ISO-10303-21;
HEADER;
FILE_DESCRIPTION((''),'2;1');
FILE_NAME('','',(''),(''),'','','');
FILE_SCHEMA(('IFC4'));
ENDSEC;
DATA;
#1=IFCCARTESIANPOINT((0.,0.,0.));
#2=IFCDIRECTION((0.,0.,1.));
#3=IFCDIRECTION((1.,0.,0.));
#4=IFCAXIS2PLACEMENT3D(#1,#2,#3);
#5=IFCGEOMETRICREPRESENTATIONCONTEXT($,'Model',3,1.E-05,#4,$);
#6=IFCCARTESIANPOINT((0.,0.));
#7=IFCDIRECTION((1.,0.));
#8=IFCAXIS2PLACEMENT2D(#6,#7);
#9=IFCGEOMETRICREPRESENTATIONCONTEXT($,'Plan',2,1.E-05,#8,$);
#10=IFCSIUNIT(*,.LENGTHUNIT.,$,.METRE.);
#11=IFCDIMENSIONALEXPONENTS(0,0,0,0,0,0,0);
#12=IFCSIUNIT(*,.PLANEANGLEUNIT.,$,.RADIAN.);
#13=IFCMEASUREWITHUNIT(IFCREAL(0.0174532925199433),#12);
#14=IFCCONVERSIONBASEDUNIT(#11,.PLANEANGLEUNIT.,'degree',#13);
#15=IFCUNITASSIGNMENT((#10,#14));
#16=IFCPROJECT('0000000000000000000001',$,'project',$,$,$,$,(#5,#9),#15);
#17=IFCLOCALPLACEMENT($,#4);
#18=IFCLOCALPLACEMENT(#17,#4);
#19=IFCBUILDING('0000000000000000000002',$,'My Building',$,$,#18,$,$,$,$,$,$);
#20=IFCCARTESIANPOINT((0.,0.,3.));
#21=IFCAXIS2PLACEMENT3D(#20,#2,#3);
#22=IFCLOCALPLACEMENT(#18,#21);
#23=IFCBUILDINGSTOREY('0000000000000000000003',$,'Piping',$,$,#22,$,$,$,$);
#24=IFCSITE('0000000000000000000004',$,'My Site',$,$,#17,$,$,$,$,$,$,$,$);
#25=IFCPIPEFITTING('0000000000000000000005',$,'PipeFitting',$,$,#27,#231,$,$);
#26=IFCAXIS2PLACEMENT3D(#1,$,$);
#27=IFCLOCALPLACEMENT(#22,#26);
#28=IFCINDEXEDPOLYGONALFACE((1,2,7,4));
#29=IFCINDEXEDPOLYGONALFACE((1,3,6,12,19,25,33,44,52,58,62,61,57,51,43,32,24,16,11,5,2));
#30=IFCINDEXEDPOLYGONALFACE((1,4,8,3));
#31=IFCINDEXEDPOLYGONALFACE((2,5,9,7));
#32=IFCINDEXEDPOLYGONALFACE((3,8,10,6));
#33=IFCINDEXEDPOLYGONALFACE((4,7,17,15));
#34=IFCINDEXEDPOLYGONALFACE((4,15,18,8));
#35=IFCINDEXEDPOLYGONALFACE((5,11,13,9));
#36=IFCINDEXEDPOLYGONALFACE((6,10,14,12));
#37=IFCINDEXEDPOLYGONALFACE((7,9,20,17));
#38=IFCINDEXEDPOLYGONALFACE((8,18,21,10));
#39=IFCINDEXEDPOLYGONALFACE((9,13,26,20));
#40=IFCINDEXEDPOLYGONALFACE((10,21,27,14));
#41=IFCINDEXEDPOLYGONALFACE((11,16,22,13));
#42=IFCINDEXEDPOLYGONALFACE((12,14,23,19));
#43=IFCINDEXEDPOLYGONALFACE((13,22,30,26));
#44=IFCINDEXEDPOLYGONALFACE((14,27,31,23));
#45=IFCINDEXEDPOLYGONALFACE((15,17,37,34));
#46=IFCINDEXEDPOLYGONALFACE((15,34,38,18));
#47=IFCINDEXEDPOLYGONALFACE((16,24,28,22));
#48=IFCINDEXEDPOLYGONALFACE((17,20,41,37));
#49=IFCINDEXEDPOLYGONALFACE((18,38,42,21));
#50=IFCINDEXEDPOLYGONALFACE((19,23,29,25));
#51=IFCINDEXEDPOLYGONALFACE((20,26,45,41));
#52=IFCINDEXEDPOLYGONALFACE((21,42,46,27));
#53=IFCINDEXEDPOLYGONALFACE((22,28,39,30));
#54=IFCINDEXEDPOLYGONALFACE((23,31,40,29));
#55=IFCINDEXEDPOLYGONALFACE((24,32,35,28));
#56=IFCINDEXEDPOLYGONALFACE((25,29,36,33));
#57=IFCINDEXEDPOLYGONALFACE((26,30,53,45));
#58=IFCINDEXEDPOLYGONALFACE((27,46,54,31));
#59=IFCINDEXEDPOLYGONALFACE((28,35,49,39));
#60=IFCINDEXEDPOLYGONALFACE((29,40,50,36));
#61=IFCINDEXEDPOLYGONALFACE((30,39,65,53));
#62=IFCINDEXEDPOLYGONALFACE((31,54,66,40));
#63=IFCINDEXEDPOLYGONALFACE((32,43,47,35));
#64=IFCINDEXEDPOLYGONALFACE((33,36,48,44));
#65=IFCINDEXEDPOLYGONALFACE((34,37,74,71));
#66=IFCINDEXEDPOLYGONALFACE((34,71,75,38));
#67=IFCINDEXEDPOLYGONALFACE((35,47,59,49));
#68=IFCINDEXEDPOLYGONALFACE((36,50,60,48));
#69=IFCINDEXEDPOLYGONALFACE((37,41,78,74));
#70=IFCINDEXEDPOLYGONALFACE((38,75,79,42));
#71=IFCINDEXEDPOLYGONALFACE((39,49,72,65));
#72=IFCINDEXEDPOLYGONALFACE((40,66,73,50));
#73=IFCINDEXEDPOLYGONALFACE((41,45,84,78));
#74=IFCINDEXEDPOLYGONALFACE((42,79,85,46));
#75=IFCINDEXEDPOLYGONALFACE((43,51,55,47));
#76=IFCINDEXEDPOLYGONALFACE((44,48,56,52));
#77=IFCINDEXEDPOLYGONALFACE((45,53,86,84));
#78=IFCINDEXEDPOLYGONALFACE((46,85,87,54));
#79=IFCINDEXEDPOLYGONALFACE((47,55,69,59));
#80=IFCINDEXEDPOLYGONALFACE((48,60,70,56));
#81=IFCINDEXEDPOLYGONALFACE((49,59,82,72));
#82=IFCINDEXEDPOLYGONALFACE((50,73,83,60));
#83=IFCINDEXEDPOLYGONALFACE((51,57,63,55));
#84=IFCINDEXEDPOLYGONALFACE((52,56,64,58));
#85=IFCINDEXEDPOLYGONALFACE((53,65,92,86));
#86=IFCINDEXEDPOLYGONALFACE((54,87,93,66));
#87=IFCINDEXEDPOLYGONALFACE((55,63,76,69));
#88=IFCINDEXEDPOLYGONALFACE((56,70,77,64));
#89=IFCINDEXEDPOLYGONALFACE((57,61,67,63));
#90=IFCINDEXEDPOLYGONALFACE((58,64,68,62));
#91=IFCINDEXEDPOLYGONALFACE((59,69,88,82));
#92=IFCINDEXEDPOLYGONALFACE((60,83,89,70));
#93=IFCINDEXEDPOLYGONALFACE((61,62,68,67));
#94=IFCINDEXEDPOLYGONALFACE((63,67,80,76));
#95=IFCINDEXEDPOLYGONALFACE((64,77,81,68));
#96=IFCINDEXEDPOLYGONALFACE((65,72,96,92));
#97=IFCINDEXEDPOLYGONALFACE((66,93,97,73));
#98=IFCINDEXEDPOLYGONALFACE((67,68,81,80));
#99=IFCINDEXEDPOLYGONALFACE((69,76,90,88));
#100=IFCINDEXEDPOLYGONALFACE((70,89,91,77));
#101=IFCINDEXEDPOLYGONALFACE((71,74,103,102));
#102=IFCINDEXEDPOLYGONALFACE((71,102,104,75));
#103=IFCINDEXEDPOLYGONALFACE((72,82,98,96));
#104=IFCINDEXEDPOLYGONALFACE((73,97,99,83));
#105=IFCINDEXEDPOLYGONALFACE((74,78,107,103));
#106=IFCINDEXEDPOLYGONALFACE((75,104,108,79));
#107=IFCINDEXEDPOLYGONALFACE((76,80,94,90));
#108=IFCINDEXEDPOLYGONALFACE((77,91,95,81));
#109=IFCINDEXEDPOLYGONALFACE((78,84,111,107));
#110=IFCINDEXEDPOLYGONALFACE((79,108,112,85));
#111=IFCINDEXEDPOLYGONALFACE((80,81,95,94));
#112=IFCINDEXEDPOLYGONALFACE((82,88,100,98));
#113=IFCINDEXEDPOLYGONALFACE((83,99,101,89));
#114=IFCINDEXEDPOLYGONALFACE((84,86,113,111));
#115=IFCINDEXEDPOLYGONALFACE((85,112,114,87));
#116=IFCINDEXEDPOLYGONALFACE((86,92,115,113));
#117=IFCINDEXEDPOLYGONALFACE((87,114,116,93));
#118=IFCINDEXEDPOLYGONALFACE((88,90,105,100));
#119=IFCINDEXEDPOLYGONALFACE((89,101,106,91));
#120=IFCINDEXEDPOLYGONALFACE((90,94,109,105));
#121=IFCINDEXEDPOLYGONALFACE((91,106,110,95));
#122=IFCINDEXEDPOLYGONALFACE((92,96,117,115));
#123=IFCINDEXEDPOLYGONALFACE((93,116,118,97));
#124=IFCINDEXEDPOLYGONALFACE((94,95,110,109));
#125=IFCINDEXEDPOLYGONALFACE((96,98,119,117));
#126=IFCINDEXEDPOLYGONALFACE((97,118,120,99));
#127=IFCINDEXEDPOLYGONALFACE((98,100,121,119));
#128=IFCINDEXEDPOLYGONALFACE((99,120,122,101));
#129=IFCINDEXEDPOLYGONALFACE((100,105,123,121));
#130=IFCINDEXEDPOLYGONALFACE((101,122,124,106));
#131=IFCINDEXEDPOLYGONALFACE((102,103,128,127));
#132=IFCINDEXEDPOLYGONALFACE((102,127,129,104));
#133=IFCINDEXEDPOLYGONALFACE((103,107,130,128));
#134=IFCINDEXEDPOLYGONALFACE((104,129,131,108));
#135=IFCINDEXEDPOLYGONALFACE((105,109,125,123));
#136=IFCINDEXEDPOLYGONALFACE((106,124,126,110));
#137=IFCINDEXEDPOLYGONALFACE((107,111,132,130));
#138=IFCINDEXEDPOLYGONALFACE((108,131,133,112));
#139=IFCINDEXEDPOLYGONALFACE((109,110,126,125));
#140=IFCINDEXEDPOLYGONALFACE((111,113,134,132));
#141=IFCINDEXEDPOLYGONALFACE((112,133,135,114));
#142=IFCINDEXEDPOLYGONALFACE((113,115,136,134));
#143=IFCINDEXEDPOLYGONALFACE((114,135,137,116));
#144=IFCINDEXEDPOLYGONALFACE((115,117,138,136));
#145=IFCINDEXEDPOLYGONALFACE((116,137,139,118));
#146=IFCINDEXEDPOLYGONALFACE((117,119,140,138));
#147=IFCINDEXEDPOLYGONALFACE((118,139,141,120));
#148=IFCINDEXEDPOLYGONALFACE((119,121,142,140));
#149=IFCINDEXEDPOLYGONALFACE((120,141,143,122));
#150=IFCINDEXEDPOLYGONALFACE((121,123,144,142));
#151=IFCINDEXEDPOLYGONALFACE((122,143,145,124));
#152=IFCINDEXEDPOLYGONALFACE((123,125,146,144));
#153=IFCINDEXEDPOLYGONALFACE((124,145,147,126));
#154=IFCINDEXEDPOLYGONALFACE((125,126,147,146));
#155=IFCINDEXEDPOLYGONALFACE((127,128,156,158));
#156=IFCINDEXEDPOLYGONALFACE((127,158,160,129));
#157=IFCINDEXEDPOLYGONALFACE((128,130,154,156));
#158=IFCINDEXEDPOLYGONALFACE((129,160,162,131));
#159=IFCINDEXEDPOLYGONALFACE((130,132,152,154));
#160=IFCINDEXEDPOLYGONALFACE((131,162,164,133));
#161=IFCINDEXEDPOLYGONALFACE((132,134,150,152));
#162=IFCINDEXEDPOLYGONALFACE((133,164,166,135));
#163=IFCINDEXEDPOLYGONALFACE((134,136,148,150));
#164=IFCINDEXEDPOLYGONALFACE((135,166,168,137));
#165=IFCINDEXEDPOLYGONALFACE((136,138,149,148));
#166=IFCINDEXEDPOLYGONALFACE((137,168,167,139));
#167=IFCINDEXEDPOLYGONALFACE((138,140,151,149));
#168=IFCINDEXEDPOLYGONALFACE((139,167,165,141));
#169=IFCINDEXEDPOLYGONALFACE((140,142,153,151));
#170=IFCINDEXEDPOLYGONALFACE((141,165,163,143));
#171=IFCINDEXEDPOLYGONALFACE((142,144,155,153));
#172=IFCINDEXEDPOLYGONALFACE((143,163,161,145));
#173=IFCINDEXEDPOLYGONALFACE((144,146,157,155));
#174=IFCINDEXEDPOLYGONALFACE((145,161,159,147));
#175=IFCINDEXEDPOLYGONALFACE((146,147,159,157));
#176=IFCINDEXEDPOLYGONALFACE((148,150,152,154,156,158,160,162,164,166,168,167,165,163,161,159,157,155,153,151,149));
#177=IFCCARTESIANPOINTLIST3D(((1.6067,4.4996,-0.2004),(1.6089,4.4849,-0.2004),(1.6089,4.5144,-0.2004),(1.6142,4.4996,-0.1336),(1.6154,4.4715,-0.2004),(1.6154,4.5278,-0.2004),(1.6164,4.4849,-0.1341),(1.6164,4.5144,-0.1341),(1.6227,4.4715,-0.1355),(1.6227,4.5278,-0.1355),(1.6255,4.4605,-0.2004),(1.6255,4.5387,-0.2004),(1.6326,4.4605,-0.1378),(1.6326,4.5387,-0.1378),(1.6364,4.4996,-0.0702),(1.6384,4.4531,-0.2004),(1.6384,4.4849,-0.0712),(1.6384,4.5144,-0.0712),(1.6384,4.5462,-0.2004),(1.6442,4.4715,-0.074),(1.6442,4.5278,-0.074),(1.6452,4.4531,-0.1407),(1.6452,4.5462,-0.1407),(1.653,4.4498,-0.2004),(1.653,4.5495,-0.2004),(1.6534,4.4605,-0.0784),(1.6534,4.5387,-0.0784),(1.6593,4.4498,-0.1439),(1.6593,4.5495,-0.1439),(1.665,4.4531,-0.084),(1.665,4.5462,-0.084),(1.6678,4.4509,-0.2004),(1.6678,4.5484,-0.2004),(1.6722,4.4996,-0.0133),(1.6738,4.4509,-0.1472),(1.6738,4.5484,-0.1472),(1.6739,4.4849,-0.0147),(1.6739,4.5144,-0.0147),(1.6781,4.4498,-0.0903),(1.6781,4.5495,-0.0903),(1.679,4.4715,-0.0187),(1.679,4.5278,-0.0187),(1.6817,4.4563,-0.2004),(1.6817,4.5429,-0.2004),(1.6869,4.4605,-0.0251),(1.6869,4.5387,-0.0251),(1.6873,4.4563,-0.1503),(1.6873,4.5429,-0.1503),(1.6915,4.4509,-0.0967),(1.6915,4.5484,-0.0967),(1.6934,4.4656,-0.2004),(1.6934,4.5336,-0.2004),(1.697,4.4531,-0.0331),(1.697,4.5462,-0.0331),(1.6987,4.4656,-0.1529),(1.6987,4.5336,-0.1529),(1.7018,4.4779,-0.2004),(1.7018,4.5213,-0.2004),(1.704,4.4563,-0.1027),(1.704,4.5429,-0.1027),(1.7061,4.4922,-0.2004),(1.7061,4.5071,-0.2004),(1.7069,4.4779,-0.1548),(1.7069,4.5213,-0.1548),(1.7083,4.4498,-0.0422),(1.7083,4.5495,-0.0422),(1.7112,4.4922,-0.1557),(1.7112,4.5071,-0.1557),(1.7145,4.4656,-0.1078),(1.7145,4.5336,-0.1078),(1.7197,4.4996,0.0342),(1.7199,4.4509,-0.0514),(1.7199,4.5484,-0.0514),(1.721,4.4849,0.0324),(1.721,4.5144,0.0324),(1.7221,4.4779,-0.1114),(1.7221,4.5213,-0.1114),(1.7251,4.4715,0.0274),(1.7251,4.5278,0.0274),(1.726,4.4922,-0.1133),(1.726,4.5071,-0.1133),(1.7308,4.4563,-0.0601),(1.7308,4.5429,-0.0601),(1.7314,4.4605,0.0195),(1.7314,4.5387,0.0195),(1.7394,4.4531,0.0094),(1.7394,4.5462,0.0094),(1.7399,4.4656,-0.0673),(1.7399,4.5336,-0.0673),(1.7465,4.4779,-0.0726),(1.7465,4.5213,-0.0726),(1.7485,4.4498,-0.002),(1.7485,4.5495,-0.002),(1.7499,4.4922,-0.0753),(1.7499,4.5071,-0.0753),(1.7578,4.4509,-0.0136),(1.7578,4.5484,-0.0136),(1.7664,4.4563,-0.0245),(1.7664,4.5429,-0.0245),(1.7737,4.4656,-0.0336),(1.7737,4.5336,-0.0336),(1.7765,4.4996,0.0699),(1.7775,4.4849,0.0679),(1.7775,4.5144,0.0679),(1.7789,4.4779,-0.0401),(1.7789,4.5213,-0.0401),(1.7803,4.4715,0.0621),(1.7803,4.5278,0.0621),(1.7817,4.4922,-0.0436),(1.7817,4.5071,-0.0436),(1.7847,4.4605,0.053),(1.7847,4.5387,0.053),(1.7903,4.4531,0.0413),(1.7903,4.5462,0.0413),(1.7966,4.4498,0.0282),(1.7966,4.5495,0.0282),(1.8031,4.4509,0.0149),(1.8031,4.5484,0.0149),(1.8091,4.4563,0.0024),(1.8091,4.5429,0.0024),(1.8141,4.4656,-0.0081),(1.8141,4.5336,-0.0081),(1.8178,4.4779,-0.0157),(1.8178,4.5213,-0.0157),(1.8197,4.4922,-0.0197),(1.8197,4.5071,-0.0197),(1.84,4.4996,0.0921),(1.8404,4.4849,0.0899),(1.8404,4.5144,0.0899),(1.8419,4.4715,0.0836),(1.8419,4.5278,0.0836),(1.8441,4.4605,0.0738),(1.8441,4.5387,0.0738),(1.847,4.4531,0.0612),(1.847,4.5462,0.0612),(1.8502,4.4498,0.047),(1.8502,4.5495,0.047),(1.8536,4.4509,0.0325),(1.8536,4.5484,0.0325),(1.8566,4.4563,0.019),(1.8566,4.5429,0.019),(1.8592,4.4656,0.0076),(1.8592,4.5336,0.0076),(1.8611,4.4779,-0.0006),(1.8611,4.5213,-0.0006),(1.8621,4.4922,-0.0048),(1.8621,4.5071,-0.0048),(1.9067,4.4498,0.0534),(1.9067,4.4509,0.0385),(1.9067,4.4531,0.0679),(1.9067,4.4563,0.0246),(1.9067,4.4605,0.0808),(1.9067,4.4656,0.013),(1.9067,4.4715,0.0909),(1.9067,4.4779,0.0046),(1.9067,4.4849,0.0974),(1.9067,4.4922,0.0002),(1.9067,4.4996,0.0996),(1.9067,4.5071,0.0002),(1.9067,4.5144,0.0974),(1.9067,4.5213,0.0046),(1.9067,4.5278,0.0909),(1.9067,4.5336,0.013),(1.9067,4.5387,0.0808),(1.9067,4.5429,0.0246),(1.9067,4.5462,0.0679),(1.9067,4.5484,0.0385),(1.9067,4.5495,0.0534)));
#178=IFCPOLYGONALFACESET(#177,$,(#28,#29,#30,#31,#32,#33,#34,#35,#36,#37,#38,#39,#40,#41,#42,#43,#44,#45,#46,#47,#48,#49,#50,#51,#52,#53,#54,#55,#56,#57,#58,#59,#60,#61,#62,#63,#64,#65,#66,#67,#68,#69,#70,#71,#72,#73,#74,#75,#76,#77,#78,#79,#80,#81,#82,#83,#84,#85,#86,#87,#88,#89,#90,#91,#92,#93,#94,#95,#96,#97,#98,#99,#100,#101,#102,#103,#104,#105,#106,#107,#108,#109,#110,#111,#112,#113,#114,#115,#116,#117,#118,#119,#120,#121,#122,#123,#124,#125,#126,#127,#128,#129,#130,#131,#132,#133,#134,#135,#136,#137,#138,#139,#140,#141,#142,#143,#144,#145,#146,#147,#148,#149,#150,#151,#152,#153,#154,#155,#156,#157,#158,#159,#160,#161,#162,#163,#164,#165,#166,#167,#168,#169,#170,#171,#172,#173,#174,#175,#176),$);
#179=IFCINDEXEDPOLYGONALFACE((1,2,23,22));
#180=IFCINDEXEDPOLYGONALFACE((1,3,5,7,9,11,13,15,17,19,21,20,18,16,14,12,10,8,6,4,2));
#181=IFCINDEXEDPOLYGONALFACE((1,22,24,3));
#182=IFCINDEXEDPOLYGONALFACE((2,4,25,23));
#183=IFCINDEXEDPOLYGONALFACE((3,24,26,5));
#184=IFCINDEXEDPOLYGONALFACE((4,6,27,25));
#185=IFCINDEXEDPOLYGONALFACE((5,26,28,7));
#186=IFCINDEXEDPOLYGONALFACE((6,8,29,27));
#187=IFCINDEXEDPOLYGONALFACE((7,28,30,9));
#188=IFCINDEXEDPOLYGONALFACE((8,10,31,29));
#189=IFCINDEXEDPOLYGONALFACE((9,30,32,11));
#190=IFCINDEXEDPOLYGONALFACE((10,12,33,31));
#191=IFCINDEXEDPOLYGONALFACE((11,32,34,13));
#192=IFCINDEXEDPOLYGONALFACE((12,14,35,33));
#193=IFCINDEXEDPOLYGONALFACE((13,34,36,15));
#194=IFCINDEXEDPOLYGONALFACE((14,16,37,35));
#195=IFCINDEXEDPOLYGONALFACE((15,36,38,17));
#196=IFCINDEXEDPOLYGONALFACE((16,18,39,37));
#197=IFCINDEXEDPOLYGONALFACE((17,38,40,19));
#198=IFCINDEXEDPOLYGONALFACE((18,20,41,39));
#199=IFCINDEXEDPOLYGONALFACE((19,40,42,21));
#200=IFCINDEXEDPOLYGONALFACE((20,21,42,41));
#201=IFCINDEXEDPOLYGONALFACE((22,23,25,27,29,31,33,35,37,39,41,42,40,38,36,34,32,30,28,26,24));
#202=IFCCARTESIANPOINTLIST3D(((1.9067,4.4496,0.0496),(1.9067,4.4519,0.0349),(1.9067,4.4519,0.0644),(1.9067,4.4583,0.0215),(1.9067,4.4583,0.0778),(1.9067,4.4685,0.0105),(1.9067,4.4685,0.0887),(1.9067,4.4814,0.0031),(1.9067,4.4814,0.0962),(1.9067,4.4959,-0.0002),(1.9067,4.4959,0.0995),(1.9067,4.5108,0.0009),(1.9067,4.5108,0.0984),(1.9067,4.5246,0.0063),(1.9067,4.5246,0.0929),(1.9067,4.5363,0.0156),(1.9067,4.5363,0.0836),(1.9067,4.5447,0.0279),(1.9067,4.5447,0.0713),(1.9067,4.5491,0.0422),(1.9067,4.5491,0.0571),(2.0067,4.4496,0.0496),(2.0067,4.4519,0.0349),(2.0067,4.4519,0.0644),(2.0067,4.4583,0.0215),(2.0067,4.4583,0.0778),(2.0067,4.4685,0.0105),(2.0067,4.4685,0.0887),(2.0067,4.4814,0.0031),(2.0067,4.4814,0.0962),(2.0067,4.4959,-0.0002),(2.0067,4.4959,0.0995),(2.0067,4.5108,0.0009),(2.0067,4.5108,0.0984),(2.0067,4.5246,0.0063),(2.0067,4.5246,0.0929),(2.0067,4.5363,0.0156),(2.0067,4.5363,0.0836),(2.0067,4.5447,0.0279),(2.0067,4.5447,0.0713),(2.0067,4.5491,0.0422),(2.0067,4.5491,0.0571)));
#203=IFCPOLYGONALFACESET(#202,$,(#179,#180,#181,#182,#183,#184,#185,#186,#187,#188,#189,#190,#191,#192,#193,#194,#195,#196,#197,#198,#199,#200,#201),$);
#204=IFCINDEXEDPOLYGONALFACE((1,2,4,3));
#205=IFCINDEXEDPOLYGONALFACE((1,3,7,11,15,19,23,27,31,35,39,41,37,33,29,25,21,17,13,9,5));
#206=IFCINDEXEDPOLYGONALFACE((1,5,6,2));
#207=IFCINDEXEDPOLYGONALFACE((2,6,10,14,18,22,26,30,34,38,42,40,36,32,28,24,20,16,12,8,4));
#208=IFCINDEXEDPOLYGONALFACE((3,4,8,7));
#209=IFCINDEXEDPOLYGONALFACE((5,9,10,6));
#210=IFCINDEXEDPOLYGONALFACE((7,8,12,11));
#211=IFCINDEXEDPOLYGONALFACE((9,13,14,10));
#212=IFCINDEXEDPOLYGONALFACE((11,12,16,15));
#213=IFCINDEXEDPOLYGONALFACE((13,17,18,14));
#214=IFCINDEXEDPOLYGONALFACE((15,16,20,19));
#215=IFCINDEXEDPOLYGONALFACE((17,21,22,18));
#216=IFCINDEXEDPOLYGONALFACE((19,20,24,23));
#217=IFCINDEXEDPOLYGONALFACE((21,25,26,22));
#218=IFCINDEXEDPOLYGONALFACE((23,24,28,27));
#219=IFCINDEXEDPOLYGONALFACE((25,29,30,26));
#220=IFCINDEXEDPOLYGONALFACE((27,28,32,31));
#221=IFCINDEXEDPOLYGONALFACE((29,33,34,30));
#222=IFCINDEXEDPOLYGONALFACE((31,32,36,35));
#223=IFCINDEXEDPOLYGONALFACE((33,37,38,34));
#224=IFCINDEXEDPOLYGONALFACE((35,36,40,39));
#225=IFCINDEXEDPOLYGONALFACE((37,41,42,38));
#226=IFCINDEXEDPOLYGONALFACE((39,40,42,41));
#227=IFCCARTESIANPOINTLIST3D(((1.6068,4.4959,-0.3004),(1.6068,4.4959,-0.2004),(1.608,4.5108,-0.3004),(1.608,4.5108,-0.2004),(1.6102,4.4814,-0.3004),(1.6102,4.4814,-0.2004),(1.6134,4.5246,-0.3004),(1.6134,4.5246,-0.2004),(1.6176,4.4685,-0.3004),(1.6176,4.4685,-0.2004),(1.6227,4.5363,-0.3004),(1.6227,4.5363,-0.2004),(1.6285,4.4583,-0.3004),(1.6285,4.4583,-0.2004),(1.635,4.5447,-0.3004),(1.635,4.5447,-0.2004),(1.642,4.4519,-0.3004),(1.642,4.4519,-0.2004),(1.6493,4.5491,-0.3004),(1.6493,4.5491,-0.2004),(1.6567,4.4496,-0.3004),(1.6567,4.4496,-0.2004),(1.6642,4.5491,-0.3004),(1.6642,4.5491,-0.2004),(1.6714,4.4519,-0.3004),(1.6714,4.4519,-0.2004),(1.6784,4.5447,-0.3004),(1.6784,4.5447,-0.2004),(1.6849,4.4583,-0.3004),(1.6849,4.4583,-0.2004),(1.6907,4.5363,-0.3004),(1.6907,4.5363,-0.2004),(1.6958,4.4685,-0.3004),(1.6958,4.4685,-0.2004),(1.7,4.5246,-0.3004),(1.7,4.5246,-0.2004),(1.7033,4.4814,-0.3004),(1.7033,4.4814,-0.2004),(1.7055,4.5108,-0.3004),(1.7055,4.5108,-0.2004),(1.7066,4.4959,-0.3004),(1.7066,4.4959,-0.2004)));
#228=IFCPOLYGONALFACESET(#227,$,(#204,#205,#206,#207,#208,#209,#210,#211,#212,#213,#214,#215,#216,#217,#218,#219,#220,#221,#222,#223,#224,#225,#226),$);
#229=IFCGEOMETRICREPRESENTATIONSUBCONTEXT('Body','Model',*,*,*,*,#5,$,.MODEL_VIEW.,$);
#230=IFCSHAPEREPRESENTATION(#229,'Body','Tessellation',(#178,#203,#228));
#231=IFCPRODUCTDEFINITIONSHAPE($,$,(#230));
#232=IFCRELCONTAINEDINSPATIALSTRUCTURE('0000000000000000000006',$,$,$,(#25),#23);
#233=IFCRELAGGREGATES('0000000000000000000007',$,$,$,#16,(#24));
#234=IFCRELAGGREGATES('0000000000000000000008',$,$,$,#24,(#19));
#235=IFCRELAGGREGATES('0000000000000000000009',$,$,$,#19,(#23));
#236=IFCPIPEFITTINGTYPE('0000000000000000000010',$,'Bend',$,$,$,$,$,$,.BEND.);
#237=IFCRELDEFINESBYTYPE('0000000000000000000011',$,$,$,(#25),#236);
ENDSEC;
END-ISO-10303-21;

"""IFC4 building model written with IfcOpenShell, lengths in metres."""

from ifc_helpers import new_model, entity, si_unit, converted_unit, frame, origin_with_axes, origin_2d_with_axis, place, context, subcontext, project, spatial, circle, extrude, source, transform, mapped, type_object, type_shapes, element, save


model = new_model("IFC4")

# Units and contexts
model_context = context("Model", 3, precision=1e-05, world=origin_with_axes())
plan_context = context("Plan", 2, precision=1e-05, world=origin_2d_with_axis())
body_context = subcontext(model_context, "Body", "Model", "MODEL_VIEW")
ifc_project = project(units=[si_unit("LENGTHUNIT", "METRE"), converted_unit("PLANEANGLEUNIT", "degree", entity("IfcReal", 0.0174532925199433), si_unit("PLANEANGLEUNIT", "RADIAN"), dimensions=[0, 0, 0, 0, 0, 0, 0])], contexts=[model_context, plan_context])

# Site, building, storey
site_placement = place(None, origin_with_axes())
site = spatial("IfcSite", under=ifc_project, at=site_placement, Name="My Site")
building_placement = place(site_placement, origin_with_axes())
building = spatial("IfcBuilding", under=site, at=building_placement, Name="My Building")
storey_placement = place(building_placement, frame((0.0, 0.0, 3.0), z_axis=(0.0, 0.0, 1.0), x_axis=(1.0, 0.0, 0.0)))
storey = spatial("IfcBuildingStorey", under=building, at=storey_placement, Name="Piping")

# Pipe fitting
pipe_fitting_type_1 = type_object("IfcPipeFittingType", Name="Bend", PredefinedType="BEND")
shared_shape = source(origin_with_axes(), body_context, "Body", "SolidModel", [
    entity("IfcSweptDiskSolid", entity("IfcIndexedPolyCurve", entity("IfcCartesianPointList3D", [[0.0, 0.0, 0.1], [0.0, -0.0732, 0.2768], [0.0, -0.25, 0.35]]), [entity("IfcArcIndex", [1, 2, 3])]), 0.05),
    extrude(circle(Radius=0.05), origin_with_axes(), (0.0, 0.0, 1.0), 0.1),
    extrude(circle(Radius=0.05), frame((0.0, -0.25, 0.35), z_axis=(0.0, -1.0, 0.0), x_axis=(1.0, 0.0, 0.0)), (0.0, 0.0, 1.0), 0.1),
])
type_shapes(pipe_fitting_type_1, [shared_shape])
for number, where, z_axis, x_axis, name in (
    (1, (2.0067, 4.4996, 0.0496), (-1.0, 0.0, 0.0), (0.0, -1.0, 0.0), "PipeFitting"),
):
    element("IfcPipeFitting", number, at=place(storey_placement, frame(where, z_axis=z_axis, x_axis=x_axis)), inside=storey, type_object=pipe_fitting_type_1, Name=name, context=body_context, shape_type="MappedRepresentation", body=[
        mapped(shared_shape, transform((0.0, 0.0, 0.0), x_axis=(1.0, 0.0, 0.0), y_axis=(0.0, 1.0, 0.0), z_axis=(0.0, 0.0, 1.0), scale=1.0)),
    ])

save(model, "model.ifc")
